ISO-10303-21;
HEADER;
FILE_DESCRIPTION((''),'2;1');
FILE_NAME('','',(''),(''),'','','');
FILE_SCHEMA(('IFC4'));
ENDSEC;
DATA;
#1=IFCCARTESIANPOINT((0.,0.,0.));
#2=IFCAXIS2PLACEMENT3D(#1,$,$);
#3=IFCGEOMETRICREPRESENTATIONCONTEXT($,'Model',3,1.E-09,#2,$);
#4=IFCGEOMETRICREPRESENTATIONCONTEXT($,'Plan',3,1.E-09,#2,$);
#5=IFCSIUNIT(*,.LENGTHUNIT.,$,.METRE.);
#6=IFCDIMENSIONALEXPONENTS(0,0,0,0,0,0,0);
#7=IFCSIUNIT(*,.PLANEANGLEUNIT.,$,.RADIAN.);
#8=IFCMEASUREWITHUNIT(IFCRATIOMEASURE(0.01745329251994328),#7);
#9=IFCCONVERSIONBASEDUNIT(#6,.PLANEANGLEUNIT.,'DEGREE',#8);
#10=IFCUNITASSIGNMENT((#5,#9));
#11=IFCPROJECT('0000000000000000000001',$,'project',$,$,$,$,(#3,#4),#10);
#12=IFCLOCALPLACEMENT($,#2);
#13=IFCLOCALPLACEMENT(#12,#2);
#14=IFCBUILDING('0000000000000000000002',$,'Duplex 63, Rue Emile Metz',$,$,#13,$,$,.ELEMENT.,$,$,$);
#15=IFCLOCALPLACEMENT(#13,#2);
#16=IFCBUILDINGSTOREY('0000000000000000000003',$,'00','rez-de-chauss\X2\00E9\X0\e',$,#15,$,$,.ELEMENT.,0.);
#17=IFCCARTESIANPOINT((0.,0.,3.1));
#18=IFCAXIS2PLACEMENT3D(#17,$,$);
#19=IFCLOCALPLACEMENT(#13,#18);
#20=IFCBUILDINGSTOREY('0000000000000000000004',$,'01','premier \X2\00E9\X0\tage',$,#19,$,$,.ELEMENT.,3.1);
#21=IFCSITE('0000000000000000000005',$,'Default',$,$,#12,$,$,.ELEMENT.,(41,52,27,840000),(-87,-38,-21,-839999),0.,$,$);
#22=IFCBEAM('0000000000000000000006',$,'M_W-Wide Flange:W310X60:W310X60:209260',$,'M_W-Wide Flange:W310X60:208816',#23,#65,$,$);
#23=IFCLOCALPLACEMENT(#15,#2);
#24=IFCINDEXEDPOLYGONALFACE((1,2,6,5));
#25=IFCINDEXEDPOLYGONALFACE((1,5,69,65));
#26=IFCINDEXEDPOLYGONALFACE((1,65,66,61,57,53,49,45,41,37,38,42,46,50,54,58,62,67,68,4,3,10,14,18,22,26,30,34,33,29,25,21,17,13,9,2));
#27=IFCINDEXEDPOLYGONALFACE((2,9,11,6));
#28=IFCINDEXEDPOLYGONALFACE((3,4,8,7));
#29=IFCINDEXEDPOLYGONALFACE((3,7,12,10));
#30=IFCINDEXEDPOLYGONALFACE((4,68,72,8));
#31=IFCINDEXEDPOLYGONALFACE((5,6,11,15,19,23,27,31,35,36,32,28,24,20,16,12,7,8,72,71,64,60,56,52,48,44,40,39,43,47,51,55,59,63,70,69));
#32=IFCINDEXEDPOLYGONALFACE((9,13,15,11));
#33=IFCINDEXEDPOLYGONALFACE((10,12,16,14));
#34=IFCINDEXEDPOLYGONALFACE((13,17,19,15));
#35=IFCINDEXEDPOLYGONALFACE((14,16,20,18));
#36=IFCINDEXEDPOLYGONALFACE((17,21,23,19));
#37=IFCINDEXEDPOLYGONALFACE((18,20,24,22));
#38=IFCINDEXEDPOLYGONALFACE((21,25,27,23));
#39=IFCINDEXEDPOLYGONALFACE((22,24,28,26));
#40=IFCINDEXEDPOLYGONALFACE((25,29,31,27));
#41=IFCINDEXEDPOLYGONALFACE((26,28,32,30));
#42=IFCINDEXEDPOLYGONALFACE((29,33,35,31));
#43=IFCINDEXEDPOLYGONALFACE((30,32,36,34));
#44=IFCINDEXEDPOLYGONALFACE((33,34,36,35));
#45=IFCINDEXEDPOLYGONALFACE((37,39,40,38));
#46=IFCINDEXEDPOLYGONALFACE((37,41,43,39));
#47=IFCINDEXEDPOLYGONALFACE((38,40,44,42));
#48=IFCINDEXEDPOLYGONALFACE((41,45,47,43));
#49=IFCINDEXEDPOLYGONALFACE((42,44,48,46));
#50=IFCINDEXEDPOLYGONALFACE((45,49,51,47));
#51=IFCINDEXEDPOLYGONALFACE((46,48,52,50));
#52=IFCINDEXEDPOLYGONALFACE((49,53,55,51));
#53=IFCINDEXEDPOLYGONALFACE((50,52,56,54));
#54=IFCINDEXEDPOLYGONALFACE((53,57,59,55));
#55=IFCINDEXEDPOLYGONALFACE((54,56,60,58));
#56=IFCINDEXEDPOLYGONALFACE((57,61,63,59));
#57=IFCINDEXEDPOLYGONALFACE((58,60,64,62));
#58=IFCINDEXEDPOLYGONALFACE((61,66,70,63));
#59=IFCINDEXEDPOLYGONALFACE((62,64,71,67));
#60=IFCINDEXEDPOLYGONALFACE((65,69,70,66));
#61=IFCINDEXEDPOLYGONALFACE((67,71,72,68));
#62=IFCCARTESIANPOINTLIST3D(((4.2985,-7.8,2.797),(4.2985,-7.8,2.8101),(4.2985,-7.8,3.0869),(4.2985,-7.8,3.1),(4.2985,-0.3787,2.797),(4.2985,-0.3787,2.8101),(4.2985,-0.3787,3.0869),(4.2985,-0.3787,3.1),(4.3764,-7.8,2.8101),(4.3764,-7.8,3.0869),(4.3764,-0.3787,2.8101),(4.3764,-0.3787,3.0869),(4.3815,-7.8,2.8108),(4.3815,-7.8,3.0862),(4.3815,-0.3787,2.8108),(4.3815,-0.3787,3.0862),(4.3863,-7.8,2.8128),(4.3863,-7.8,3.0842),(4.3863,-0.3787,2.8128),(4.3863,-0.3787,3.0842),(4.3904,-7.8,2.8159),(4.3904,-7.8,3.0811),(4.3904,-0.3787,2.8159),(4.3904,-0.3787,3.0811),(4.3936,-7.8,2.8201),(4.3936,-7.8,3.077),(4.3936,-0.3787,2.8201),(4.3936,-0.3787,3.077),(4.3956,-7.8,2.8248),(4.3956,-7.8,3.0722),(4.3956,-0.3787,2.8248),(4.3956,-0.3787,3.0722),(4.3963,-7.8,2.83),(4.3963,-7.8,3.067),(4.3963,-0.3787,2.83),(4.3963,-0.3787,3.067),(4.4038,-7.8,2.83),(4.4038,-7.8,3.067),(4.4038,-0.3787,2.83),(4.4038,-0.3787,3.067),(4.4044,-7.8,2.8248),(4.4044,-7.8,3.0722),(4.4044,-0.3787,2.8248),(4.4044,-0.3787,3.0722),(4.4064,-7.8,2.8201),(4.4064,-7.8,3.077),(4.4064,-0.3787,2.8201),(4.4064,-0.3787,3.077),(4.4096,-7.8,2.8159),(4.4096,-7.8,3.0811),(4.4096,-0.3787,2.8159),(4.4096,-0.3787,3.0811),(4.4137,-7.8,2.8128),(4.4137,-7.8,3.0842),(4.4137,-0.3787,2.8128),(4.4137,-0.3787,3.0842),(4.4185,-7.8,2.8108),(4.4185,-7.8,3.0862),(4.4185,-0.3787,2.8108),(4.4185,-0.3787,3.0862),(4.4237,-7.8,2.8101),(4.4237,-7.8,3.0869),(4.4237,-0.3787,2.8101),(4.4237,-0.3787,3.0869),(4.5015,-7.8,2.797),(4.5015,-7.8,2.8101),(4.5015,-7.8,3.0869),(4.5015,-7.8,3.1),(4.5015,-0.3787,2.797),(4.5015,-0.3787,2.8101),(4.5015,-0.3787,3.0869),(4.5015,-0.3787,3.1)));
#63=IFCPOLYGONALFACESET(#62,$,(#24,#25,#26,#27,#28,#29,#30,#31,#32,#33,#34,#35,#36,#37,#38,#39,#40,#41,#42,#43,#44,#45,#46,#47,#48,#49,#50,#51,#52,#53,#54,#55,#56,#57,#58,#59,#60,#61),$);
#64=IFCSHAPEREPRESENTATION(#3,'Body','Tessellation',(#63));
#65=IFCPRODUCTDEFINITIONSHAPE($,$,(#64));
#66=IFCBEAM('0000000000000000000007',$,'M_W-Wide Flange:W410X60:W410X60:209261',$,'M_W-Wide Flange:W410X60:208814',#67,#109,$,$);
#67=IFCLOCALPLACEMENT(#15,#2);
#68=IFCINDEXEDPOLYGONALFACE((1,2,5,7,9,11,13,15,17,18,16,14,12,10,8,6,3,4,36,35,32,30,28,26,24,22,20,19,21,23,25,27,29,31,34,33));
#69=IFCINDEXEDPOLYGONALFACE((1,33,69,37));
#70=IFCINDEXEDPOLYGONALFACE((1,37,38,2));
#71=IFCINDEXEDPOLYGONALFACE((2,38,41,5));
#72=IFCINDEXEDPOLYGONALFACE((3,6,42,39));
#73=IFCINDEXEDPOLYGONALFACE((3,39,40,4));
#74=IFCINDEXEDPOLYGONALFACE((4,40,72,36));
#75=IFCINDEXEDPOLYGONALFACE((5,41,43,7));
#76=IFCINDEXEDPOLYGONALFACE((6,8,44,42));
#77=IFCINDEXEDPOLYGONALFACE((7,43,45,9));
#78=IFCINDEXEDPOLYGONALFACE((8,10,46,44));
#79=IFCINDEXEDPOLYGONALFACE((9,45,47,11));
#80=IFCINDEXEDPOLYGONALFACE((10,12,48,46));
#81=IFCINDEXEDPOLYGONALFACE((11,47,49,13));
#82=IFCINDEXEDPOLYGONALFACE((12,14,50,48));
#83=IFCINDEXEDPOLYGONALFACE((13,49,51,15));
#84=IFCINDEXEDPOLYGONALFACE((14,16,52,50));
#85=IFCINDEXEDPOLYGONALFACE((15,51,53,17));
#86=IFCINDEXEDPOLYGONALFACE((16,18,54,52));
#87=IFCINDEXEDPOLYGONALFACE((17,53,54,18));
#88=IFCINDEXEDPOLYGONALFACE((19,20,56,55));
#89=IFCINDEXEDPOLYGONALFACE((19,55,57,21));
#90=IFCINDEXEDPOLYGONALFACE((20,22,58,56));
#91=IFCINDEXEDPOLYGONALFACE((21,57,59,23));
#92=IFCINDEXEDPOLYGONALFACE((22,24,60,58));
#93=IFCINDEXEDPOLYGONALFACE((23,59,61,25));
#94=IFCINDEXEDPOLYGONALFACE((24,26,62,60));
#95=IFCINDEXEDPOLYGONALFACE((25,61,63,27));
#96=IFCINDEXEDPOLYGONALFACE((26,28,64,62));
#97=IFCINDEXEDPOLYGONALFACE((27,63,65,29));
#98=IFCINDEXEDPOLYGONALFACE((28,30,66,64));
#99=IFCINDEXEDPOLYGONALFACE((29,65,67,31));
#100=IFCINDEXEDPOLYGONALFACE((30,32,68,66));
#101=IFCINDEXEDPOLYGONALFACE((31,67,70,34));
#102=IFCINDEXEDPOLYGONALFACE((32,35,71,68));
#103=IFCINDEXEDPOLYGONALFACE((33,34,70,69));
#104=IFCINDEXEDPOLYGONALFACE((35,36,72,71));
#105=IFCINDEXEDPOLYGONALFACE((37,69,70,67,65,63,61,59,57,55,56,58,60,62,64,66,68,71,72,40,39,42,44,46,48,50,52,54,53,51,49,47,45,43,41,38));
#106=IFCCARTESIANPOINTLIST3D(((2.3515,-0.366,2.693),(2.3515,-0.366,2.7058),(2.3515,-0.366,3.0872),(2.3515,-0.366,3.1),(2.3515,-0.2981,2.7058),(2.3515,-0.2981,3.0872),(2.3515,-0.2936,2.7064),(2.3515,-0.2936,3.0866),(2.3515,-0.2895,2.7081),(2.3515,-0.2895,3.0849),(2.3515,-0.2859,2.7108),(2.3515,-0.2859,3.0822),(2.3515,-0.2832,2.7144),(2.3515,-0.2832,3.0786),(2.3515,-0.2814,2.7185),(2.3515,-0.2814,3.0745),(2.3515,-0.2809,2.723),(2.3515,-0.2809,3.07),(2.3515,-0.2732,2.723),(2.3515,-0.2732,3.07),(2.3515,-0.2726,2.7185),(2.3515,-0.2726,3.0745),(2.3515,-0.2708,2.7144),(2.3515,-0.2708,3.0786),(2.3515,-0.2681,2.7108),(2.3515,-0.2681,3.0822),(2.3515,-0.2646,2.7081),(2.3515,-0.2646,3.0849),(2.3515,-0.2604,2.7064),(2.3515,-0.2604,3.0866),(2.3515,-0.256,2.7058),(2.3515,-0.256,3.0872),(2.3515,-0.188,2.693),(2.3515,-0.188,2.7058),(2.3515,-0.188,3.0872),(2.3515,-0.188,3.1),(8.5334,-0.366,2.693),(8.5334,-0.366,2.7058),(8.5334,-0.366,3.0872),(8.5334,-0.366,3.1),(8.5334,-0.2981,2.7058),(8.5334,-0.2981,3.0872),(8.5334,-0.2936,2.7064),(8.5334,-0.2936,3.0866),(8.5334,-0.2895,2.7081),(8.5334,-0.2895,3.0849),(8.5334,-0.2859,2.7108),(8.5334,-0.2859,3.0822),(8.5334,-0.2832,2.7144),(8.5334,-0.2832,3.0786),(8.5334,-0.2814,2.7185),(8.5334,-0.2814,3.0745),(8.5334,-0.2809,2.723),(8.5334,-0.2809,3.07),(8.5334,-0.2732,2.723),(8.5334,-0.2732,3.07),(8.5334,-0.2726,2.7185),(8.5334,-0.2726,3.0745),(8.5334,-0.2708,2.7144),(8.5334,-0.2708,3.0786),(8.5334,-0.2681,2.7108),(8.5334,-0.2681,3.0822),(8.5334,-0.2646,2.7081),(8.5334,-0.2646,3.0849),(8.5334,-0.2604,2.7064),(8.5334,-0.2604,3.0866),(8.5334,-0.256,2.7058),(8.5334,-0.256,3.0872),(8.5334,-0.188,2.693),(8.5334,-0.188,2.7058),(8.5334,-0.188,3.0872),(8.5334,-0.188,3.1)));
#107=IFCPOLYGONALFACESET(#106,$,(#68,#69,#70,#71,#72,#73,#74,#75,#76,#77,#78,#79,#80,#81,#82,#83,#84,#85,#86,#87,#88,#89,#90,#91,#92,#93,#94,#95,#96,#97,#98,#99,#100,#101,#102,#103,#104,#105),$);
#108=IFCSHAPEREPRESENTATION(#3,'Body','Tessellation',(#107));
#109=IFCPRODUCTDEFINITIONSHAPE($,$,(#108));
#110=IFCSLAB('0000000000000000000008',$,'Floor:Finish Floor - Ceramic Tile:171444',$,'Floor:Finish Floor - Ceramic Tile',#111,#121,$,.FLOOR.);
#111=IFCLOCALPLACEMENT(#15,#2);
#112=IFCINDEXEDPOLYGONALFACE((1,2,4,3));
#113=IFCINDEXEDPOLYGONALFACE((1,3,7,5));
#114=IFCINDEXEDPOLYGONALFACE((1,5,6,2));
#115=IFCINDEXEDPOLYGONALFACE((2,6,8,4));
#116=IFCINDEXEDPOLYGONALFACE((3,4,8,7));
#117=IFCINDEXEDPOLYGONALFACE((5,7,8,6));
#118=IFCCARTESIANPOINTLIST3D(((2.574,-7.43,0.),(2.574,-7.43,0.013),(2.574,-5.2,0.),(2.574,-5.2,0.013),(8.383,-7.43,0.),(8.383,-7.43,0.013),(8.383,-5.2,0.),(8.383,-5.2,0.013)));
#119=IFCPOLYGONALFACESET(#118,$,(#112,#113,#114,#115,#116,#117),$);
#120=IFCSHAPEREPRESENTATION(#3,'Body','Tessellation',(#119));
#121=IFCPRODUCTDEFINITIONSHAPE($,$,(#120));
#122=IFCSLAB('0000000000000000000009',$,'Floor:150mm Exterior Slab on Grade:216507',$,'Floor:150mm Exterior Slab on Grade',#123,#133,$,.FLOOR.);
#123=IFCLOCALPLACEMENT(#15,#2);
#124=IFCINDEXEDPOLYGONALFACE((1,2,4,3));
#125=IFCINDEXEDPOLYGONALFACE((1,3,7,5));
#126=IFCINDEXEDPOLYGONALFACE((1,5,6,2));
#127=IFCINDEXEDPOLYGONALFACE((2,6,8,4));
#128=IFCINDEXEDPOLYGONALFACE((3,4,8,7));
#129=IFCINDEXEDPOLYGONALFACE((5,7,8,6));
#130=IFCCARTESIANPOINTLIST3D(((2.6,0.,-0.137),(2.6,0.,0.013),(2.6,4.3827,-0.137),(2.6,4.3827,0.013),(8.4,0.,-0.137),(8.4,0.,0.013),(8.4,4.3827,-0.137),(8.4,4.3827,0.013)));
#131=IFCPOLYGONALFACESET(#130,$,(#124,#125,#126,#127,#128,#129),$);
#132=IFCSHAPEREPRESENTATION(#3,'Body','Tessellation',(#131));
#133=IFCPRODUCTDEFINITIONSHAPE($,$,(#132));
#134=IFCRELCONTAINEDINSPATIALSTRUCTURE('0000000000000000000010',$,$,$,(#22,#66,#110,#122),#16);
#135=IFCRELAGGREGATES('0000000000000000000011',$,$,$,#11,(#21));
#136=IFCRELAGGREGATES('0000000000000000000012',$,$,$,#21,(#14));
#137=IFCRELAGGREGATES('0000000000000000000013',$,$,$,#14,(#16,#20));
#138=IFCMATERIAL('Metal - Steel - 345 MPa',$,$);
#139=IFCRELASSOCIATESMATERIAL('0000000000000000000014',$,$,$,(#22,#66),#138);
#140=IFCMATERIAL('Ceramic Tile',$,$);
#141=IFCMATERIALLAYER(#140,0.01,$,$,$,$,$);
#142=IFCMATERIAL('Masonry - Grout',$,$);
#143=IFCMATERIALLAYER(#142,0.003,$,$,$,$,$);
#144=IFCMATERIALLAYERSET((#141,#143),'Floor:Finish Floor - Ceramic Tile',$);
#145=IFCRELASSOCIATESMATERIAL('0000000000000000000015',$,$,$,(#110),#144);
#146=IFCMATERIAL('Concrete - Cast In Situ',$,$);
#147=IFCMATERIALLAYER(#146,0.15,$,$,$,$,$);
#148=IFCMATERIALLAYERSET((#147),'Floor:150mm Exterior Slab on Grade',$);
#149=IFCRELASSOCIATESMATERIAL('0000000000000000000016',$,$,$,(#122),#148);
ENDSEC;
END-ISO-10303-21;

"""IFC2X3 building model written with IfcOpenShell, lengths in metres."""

from ifc_helpers import new_model, entity, si_unit, converted_unit, frame, frame_2d, origin, place, context, project, spatial, polyline, circle_curve, parameter, trimmed, segment, composite_curve, rectangle, outline, extrude, material, layer, layer_set, layer_usage, element, save


model = new_model("IFC2X3")

# Units and contexts
model_context = context("Model", 3, precision=1e-09, world=origin())
plan_context = context("Plan", 3, precision=1e-09, world=origin())
ifc_project = project(units=[si_unit("LENGTHUNIT", "METRE"), converted_unit("PLANEANGLEUNIT", "DEGREE", entity("IfcRatioMeasure", 0.01745329251994328), si_unit("PLANEANGLEUNIT", "RADIAN"), dimensions=[0, 0, 0, 0, 0, 0, 0])], contexts=[model_context, plan_context])

# Site, building, storey
site_placement = place(None, origin())
site = spatial("IfcSite", under=ifc_project, at=site_placement, Name="Default", CompositionType="ELEMENT", RefLatitude=(41, 52, 27, 840000), RefLongitude=(-87, -38, -21, -839999), RefElevation=0.0)
building_placement = place(site_placement, origin())
building = spatial("IfcBuilding", under=site, at=building_placement, Name="Duplex 63, Rue Emile Metz", CompositionType="ELEMENT")
storey_1_placement = place(building_placement, origin())
storey_1 = spatial("IfcBuildingStorey", under=building, at=storey_1_placement, Name="00", Description="rez-de-chaussée", CompositionType="ELEMENT", Elevation=0.0)

# Beams
ifc_material_1 = material(Name="Metal - Steel - 345 MPa")
beam_1_placement = place(storey_1_placement, frame((4.4, -7.8, 3.1)))
element("IfcBeam", 1, at=beam_1_placement, inside=storey_1, material=ifc_material_1, Name="M_W-Wide Flange:W310X60:W310X60:209260", ObjectType="M_W-Wide Flange:W310X60:208816", context=model_context, shape_type="SweptSolid", body=[
    extrude(outline(composite_curve([segment(polyline([(-0.1015, -0.1384), (-0.1015, -0.1515)]), True, "CONTINUOUS"), segment(polyline([(-0.1015, -0.1515), (0.1015, -0.1515)]), True, "CONTINUOUS"), segment(polyline([(0.1015, -0.1515), (0.1015, -0.1384)]), True, "CONTINUOUS"), segment(polyline([(0.1015, -0.1384), (0.0236, -0.1384)]), True, "CONTINUOUS"), segment(trimmed(circle_curve(frame_2d((0.0236, -0.1185), x_axis=(1.0, 0.0)), 0.0199), [parameter(180.0)], [parameter(270.0)], True, "PARAMETER"), False, "CONTINUOUS"), segment(polyline([(0.0037, -0.1185), (0.0037, 0.1185)]), True, "CONTINUOUS"), segment(trimmed(circle_curve(frame_2d((0.0236, 0.1185), x_axis=(1.0, 0.0)), 0.0199), [parameter(90.0)], [parameter(180.0)], True, "PARAMETER"), False, "CONTINUOUS"), segment(polyline([(0.0236, 0.1384), (0.1015, 0.1384)]), True, "CONTINUOUS"), segment(polyline([(0.1015, 0.1384), (0.1015, 0.1515)]), True, "CONTINUOUS"), segment(polyline([(0.1015, 0.1515), (-0.1015, 0.1515)]), True, "CONTINUOUS"), segment(polyline([(-0.1015, 0.1515), (-0.1015, 0.1384)]), True, "CONTINUOUS"), segment(polyline([(-0.1015, 0.1384), (-0.0237, 0.1384)]), True, "CONTINUOUS"), segment(trimmed(circle_curve(frame_2d((-0.0237, 0.1185), x_axis=(1.0, 0.0)), 0.0199), [parameter(360.0)], [parameter(90.0)], True, "PARAMETER"), False, "CONTINUOUS"), segment(polyline([(-0.0038, 0.1185), (-0.0038, -0.1185)]), True, "CONTINUOUS"), segment(trimmed(circle_curve(frame_2d((-0.0237, -0.1185), x_axis=(1.0, 0.0)), 0.0199), [parameter(270.0)], [parameter(0.0)], True, "PARAMETER"), False, "CONTINUOUS"), segment(polyline([(-0.0237, -0.1384), (-0.1015, -0.1384)]), True, "CONTINUOUS")], self_intersect=False)), frame((0.0, 0.0, -0.1515), z_axis=(0.0, -1.0, 0.0), x_axis=(1.0, 0.0, 0.0)), (0.0, 0.0, -1.0), 7.4213),
])
beam_2_placement = place(storey_1_placement, frame((8.5915, -0.277, 3.1), z_axis=(0.0, 0.0, 1.0), x_axis=(0.0, 1.0, 0.0)))
element("IfcBeam", 2, at=beam_2_placement, inside=storey_1, material=ifc_material_1, Name="M_W-Wide Flange:W410X60:W410X60:209261", ObjectType="M_W-Wide Flange:W410X60:208814", context=model_context, shape_type="SweptSolid", body=[
    extrude(outline(composite_curve([segment(polyline([(0.1907, -0.089), (0.2035, -0.089)]), True, "CONTINUOUS"), segment(polyline([(0.2035, -0.089), (0.2035, 0.089)]), True, "CONTINUOUS"), segment(polyline([(0.2035, 0.089), (0.1907, 0.089)]), True, "CONTINUOUS"), segment(polyline([(0.1907, 0.089), (0.1907, 0.021)]), True, "CONTINUOUS"), segment(trimmed(circle_curve(frame_2d((0.1735, 0.021), x_axis=(1.0, 0.0)), 0.0172), [parameter(270.0)], [parameter(360.0)], True, "PARAMETER"), False, "CONTINUOUS"), segment(polyline([(0.1735, 0.0038), (-0.1735, 0.0038)]), True, "CONTINUOUS"), segment(trimmed(circle_curve(frame_2d((-0.1735, 0.021), x_axis=(0.0, -1.0)), 0.0172), [parameter(270.0)], [parameter(360.0)], True, "PARAMETER"), False, "CONTINUOUS"), segment(polyline([(-0.1907, 0.021), (-0.1907, 0.089)]), True, "CONTINUOUS"), segment(polyline([(-0.1907, 0.089), (-0.2035, 0.089)]), True, "CONTINUOUS"), segment(polyline([(-0.2035, 0.089), (-0.2035, -0.089)]), True, "CONTINUOUS"), segment(polyline([(-0.2035, -0.089), (-0.1907, -0.089)]), True, "CONTINUOUS"), segment(polyline([(-0.1907, -0.089), (-0.1907, -0.0211)]), True, "CONTINUOUS"), segment(trimmed(circle_curve(frame_2d((-0.1735, -0.0211), x_axis=(-1.0, 0.0)), 0.0172), [parameter(270.0)], [parameter(0.0)], True, "PARAMETER"), False, "CONTINUOUS"), segment(polyline([(-0.1735, -0.0039), (0.1735, -0.0039)]), True, "CONTINUOUS"), segment(trimmed(circle_curve(frame_2d((0.1735, -0.0211), x_axis=(0.0, 1.0)), 0.0172), [parameter(270.0)], [parameter(0.0)], True, "PARAMETER"), False, "CONTINUOUS"), segment(polyline([(0.1907, -0.0211), (0.1907, -0.089)]), True, "CONTINUOUS")], self_intersect=False)), frame((0.0, 6.24, -0.2035), z_axis=(0.0, -1.0, 0.0), x_axis=(0.0, 0.0, -1.0)), (0.0, 0.0, 1.0), 6.1819),
])

# Slabs
ifc_material_2 = material(Name="Ceramic Tile")
ifc_layer_1 = layer(ifc_material_2, 0.01)
ifc_material_3 = material(Name="Masonry - Grout")
ifc_layer_2 = layer(ifc_material_3, 0.003)
ifc_layer_set_1 = layer_set([ifc_layer_1, ifc_layer_2], Name="Floor:Finish Floor - Ceramic Tile")
ifc_layer_usage_1 = layer_usage(ifc_layer_set_1, "AXIS3", "POSITIVE", 0.0)
slab_1_placement = place(storey_1_placement, frame((2.574, -7.43, 0.0)))
element("IfcSlab", 3, at=slab_1_placement, inside=storey_1, material=ifc_layer_usage_1, Name="Floor:Finish Floor - Ceramic Tile:171444", ObjectType="Floor:Finish Floor - Ceramic Tile", PredefinedType="FLOOR", context=model_context, shape_type="SweptSolid", body=[
    extrude(rectangle(XDim=5.809, YDim=2.23, at=frame_2d((0.0, 0.0), x_axis=(-1.0, 0.0))), frame((2.9045, 1.115, 0.013), z_axis=(0.0, 0.0, -1.0), x_axis=(-1.0, 0.0, 0.0)), (0.0, 0.0, 1.0), 0.013),
])
ifc_material_4 = material(Name="Concrete - Cast In Situ")
ifc_layer_3 = layer(ifc_material_4, 0.15)
ifc_layer_set_2 = layer_set([ifc_layer_3], Name="Floor:150mm Exterior Slab on Grade")
ifc_layer_usage_2 = layer_usage(ifc_layer_set_2, "AXIS3", "POSITIVE", 0.0)
slab_2_placement = place(storey_1_placement, frame((2.6, 0.0, -0.137)))
element("IfcSlab", 4, at=slab_2_placement, inside=storey_1, material=ifc_layer_usage_2, Name="Floor:150mm Exterior Slab on Grade:216507", ObjectType="Floor:150mm Exterior Slab on Grade", PredefinedType="FLOOR", context=model_context, shape_type="SweptSolid", body=[
    extrude(rectangle(XDim=5.8, YDim=4.3827, at=frame_2d((0.0, 0.0), x_axis=(-1.0, 0.0))), frame((2.9, 2.1914, 0.15), z_axis=(0.0, 0.0, -1.0), x_axis=(-1.0, 0.0, 0.0)), (0.0, 0.0, 1.0), 0.15),
])

# Shared definitions
storey_2_placement = place(building_placement, frame((0.0, 0.0, 3.1)))
storey_2 = spatial("IfcBuildingStorey", under=building, at=storey_2_placement, Name="01", Description="premier étage", CompositionType="ELEMENT", Elevation=3.1)

save(model, "model.ifc")
